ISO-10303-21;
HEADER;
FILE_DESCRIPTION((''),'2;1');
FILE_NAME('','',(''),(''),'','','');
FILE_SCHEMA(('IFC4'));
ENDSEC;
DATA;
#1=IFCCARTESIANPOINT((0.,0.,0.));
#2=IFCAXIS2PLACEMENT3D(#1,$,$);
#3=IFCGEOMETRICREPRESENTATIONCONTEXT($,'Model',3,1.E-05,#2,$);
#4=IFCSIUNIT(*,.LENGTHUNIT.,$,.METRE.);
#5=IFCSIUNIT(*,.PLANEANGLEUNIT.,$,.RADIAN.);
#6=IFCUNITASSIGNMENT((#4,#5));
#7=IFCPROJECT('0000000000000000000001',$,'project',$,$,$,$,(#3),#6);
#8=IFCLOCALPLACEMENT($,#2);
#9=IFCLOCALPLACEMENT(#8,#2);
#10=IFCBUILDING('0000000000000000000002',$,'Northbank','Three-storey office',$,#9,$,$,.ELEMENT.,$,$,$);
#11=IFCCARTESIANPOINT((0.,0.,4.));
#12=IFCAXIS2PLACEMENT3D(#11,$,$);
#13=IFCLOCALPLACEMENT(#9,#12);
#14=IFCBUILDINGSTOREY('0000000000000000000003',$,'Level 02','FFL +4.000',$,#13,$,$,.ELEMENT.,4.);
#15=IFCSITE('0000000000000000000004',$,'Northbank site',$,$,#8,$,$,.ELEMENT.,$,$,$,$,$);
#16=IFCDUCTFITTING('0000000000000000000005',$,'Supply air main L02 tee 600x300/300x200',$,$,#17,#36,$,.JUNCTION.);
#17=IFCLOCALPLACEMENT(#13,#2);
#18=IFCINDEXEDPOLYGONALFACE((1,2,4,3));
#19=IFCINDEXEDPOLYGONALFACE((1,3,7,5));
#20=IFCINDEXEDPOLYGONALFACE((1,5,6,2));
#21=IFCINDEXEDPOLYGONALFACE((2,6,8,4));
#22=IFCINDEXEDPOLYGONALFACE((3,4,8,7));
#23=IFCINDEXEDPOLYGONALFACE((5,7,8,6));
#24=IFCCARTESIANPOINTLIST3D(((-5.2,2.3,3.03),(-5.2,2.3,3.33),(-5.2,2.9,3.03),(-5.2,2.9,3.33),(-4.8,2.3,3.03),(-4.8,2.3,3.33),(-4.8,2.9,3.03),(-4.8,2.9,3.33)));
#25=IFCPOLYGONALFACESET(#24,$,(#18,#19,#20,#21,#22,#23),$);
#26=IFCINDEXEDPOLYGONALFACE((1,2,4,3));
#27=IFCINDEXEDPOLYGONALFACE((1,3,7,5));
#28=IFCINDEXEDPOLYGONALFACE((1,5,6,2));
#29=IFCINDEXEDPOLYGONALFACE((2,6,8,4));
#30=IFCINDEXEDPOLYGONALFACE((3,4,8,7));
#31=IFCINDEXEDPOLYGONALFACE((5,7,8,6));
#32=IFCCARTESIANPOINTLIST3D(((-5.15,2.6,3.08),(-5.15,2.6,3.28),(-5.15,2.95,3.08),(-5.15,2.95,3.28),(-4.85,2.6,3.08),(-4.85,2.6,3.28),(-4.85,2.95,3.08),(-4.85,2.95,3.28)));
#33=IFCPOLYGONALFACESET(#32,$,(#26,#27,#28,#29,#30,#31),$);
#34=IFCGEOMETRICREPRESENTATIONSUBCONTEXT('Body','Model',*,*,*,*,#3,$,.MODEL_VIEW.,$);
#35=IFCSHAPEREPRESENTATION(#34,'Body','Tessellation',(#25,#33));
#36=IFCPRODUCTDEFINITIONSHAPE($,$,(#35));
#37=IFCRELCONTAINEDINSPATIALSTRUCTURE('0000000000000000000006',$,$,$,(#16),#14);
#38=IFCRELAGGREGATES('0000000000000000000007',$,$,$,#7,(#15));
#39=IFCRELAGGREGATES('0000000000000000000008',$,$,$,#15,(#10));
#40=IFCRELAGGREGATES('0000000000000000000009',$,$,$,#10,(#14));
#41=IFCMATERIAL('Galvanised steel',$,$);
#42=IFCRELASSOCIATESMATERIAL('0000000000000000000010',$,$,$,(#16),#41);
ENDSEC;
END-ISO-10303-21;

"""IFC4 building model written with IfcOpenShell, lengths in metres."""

from ifc_helpers import new_model, si_unit, frame, origin, place, context, subcontext, project, spatial, rectangle, extrude, material, element, save


model = new_model("IFC4")

# Units and contexts
model_context = context("Model", 3, precision=1e-05, world=origin())
body_context = subcontext(model_context, "Body", "Model", "MODEL_VIEW")
ifc_project = project(units=[si_unit("LENGTHUNIT", "METRE"), si_unit("PLANEANGLEUNIT", "RADIAN")], contexts=[model_context])

# Site, building, storey
site_placement = place(None, origin())
site = spatial("IfcSite", under=ifc_project, at=site_placement, Name="Northbank site", CompositionType="ELEMENT")
building_placement = place(site_placement, origin())
building = spatial("IfcBuilding", under=site, at=building_placement, Name="Northbank", Description="Three-storey office", CompositionType="ELEMENT")
storey_placement = place(building_placement, frame((0.0, 0.0, 4.0)))
storey = spatial("IfcBuildingStorey", under=building, at=storey_placement, Name="Level 02", Description="FFL +4.000", CompositionType="ELEMENT", Elevation=4.0)

# Shared definitions
ifc_material = material(Name="Galvanised steel")

# Duct fitting
duct_fitting_1_placement = place(storey_placement, frame((0.0, 0.0, -4.0)))
element("IfcDuctFitting", 1, at=duct_fitting_1_placement, inside=storey, material=ifc_material, Name="Supply air main L02 tee 600x300/300x200", PredefinedType="JUNCTION", context=body_context, shape_type="SweptSolid", body=[
    extrude(rectangle(XDim=0.6, YDim=0.3), frame((-4.8, 2.6, 7.18), z_axis=(-1.0, 0.0, 0.0), x_axis=(0.0, -1.0, 0.0)), (0.0, 0.0, 1.0), 0.4),
    extrude(rectangle(XDim=0.3, YDim=0.2), frame((-5.0, 2.6, 7.18), z_axis=(0.0, 1.0, 0.0), x_axis=(-1.0, 0.0, 0.0)), (0.0, 0.0, 1.0), 0.35),
])

save(model, "model.ifc")
